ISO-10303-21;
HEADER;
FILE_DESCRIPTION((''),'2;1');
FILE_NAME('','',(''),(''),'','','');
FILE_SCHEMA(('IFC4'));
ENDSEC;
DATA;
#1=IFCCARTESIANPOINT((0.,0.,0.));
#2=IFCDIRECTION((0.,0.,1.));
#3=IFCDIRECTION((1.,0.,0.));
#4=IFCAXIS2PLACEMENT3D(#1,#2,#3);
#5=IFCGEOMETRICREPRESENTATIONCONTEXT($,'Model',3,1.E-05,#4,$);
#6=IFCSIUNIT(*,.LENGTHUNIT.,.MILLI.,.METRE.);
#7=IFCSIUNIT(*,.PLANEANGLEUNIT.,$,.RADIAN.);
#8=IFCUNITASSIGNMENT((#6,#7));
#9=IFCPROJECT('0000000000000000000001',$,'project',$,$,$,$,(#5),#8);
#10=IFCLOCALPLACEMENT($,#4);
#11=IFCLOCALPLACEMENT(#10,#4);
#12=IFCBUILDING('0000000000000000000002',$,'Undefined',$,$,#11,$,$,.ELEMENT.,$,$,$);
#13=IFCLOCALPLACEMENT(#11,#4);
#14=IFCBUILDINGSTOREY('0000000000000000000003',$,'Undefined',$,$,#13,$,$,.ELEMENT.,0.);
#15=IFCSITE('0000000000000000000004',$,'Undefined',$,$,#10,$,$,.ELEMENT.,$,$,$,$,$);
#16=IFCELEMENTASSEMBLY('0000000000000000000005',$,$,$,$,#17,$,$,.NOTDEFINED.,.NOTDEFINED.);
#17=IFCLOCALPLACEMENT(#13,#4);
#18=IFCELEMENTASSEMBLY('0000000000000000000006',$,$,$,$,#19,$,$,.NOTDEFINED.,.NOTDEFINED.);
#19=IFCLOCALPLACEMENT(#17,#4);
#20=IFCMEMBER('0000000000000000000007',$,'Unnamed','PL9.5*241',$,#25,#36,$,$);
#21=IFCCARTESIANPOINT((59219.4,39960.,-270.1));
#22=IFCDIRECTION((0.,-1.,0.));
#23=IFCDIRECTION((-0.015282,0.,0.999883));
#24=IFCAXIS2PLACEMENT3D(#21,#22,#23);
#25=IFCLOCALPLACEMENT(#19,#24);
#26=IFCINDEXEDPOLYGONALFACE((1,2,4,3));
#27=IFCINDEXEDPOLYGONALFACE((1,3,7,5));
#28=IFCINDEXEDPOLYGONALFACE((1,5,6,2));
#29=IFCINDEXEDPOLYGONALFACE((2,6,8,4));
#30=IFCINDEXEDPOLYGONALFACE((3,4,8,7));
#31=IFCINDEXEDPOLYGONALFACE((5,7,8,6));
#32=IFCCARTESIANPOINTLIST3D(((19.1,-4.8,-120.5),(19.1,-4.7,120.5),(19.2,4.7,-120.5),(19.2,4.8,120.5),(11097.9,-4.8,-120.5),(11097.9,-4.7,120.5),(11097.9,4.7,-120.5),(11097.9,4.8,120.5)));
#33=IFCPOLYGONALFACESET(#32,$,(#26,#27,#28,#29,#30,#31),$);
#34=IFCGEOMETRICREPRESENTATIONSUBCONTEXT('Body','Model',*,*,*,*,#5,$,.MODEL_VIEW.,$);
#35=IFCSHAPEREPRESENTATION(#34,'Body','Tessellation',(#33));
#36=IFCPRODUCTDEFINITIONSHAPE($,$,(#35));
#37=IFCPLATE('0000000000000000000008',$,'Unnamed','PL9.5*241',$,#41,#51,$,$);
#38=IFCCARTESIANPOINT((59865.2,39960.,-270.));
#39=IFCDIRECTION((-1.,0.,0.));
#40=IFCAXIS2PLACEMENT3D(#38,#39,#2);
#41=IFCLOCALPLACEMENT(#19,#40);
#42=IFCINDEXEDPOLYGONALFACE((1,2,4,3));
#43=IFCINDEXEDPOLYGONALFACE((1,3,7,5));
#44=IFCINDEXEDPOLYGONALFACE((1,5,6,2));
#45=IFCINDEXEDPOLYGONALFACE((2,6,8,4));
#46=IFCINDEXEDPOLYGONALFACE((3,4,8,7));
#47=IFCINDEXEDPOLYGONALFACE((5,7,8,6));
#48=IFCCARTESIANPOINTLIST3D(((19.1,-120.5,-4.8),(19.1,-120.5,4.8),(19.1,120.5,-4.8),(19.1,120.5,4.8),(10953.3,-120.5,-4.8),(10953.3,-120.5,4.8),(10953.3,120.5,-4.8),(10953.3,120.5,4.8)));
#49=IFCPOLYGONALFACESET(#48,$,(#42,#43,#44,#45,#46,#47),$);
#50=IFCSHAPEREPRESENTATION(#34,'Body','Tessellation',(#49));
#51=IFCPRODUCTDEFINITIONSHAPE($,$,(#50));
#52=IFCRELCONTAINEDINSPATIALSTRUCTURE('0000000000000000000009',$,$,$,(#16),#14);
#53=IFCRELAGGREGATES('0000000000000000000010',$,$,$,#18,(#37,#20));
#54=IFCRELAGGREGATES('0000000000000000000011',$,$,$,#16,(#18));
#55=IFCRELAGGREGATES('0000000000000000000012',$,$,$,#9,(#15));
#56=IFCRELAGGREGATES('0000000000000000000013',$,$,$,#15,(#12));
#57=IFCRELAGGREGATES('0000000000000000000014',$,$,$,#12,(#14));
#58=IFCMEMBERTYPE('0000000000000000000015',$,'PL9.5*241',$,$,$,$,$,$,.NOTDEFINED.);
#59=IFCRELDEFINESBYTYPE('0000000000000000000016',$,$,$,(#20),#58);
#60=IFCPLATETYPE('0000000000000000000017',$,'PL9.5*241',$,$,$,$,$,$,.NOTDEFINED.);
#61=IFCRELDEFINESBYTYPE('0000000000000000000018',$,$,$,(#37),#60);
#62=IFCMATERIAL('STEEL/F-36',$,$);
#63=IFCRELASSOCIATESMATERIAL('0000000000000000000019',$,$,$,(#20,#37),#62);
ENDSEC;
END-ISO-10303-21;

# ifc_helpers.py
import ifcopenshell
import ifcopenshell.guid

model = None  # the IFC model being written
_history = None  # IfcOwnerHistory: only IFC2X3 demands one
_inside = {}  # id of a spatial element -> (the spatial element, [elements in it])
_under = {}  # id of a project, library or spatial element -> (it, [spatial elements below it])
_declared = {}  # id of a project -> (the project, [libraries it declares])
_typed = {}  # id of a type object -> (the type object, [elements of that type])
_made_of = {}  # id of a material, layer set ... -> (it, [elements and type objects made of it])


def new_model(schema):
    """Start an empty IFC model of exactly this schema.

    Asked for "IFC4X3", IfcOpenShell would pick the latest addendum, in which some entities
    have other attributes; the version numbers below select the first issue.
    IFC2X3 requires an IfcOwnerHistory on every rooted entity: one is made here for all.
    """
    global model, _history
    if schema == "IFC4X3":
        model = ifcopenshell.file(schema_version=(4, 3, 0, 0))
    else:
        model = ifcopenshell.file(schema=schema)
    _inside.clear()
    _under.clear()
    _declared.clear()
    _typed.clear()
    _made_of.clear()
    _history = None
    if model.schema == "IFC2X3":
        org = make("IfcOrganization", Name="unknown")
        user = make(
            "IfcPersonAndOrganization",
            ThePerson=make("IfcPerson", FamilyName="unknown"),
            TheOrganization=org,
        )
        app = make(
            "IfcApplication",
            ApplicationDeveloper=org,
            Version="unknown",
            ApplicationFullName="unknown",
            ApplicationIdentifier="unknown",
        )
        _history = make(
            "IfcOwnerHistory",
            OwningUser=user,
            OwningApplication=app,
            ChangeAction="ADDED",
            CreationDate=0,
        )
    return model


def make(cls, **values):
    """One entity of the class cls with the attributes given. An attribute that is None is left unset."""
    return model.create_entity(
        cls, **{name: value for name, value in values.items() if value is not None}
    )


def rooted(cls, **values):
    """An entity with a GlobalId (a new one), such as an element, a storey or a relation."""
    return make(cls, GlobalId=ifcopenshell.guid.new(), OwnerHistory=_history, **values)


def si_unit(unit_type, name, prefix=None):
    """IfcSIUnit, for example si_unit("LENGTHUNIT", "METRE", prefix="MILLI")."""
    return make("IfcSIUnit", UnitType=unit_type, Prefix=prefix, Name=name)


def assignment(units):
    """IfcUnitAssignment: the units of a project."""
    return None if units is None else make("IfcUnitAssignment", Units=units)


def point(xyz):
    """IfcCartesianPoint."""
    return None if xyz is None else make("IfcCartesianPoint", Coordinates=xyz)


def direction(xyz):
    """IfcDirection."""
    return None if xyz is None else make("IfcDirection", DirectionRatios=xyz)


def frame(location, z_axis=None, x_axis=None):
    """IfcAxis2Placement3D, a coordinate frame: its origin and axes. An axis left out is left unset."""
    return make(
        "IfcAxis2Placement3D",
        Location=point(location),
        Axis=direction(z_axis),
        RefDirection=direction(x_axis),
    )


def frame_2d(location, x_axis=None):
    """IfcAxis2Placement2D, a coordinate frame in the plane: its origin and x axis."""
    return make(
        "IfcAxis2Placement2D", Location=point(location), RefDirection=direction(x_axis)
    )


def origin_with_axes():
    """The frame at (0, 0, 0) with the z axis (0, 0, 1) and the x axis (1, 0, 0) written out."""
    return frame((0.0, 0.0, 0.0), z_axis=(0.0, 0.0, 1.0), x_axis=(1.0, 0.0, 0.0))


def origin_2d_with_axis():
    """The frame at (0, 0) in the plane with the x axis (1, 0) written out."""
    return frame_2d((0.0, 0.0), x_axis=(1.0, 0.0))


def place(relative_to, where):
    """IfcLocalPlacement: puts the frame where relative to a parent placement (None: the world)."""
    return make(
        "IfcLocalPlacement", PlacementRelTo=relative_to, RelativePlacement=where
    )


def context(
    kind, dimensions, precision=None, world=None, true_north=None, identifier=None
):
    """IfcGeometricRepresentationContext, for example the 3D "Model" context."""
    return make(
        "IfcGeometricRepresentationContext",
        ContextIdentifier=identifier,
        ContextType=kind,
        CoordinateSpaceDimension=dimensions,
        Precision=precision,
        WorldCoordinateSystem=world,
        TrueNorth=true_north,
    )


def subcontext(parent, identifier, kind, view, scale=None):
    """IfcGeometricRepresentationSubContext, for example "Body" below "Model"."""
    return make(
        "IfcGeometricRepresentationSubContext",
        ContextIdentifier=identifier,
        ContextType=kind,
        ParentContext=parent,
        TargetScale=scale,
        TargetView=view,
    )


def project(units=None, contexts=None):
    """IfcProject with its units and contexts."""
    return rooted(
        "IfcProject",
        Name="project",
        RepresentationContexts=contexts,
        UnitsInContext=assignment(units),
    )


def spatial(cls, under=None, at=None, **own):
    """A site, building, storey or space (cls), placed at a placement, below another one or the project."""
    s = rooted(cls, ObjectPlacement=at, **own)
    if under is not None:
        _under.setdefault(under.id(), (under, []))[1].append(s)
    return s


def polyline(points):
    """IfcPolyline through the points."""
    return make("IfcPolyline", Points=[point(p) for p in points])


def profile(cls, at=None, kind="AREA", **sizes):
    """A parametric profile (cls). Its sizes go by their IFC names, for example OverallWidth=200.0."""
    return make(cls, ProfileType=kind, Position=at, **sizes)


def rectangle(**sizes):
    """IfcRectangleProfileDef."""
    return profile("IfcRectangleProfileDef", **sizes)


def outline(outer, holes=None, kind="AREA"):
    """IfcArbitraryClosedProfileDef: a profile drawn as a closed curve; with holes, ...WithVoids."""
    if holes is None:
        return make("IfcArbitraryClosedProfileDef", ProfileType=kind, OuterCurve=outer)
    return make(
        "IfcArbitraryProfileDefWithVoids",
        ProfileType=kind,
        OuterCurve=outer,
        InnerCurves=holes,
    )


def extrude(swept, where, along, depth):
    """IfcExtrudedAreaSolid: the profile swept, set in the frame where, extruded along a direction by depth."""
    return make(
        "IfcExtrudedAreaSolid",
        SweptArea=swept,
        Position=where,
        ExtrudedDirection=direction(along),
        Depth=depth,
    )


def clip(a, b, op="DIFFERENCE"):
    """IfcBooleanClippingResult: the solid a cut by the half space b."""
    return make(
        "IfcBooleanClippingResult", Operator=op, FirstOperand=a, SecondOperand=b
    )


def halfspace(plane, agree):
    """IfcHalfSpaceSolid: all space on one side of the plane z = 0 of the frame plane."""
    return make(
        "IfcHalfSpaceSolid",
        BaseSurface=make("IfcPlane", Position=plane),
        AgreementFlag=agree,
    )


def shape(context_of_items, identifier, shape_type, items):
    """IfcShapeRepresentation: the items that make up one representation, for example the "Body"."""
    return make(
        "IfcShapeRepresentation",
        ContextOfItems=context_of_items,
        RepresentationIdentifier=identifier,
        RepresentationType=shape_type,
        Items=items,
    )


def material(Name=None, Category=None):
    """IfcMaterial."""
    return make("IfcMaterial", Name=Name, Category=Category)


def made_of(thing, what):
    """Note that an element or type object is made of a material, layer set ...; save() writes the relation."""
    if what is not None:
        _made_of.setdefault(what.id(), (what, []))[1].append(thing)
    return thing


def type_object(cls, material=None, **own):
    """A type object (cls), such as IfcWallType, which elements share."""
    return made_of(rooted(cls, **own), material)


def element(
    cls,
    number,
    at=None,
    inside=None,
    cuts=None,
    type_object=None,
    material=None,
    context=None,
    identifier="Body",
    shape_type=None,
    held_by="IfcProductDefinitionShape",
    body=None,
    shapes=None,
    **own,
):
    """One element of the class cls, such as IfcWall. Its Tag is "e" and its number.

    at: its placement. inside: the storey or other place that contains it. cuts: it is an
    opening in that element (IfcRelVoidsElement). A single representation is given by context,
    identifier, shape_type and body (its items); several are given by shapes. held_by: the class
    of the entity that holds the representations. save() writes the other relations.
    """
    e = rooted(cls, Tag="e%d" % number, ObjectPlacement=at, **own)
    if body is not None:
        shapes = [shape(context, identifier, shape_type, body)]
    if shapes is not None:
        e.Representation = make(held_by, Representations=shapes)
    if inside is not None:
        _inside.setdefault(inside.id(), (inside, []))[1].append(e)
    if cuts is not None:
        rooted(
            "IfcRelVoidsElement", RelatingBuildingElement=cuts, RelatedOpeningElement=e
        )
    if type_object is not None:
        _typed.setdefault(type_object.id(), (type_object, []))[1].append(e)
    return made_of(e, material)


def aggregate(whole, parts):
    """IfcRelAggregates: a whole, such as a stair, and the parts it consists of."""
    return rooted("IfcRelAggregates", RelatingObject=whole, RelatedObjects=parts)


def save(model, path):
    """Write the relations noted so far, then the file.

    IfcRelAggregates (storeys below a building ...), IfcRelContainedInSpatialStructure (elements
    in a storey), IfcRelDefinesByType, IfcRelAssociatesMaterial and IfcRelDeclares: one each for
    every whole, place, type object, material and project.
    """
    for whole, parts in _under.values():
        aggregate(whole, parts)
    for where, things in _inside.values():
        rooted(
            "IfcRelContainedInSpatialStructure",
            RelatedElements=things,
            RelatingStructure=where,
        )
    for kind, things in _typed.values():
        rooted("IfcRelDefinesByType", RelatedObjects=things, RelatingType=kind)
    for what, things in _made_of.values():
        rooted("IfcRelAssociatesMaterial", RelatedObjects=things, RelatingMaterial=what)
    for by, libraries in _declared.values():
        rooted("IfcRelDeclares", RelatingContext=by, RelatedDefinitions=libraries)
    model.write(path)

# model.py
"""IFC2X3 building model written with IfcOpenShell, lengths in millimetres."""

from ifc_helpers import new_model, si_unit, frame, origin_with_axes, origin_2d_with_axis, place, context, subcontext, project, spatial, polyline, rectangle, outline, extrude, clip, halfspace, material, type_object, element, aggregate, save


model = new_model("IFC2X3")

# Units and contexts
model_context = context("Model", 3, precision=1e-05, world=origin_with_axes())
body_context = subcontext(model_context, "Body", "Model", "MODEL_VIEW")
ifc_project = project(units=[si_unit("LENGTHUNIT", "METRE", prefix="MILLI"), si_unit("PLANEANGLEUNIT", "RADIAN")], contexts=[model_context])

# Site, building, storey
site_placement = place(None, origin_with_axes())
site = spatial("IfcSite", under=ifc_project, at=site_placement, Name="Undefined", CompositionType="ELEMENT")
building_placement = place(site_placement, origin_with_axes())
building = spatial("IfcBuilding", under=site, at=building_placement, Name="Undefined", CompositionType="ELEMENT")
storey_placement = place(building_placement, origin_with_axes())
storey = spatial("IfcBuildingStorey", under=building, at=storey_placement, Name="Undefined", CompositionType="ELEMENT", Elevation=0.0)

# Element assemblies, member
assembly_1_placement = place(storey_placement, origin_with_axes())
assembly_1 = element("IfcElementAssembly", 1, at=assembly_1_placement, inside=storey, AssemblyPlace="NOTDEFINED", PredefinedType="NOTDEFINED")
assembly_2_placement = place(assembly_1_placement, origin_with_axes())
assembly_2 = element("IfcElementAssembly", 2, at=assembly_2_placement, AssemblyPlace="NOTDEFINED", PredefinedType="NOTDEFINED")
ifc_material_1 = material(Name="STEEL/F-36")
member_type = type_object("IfcMemberType", Name="PL9.5*241", PredefinedType="NOTDEFINED")
member_placement = place(assembly_2_placement, frame((59219.4, 39960.0, -270.1), z_axis=(0.0, -1.0, 0.0), x_axis=(-0.015282, 0.0, 0.999883)))
member = element("IfcMember", 3, at=member_placement, type_object=member_type, material=ifc_material_1, Name="Unnamed", Description="PL9.5*241", context=body_context, shape_type="Clipping", body=[
    clip(extrude(rectangle(XDim=9.5, YDim=241.0, at=origin_2d_with_axis()), frame((11097.9, 0.0, 0.0), z_axis=(-1.0, 0.0, 0.0), x_axis=(0.0, -1.0, 0.0)), (0.0, 0.0, 1.0), 11097.9), halfspace(frame((19.1, 0.0, 0.0), z_axis=(0.999883, -0.015282, 0.0), x_axis=(0.0, 0.0, 1.0)), True)),
])

# Plate
plate_type_1 = type_object("IfcPlateType", Name="PL9.5*241", PredefinedType="NOTDEFINED")
plate_1_placement = place(assembly_2_placement, frame((59865.2, 39960.0, -270.0), z_axis=(-1.0, 0.0, 0.0), x_axis=(0.0, 0.0, 1.0)))
plate_1 = element("IfcPlate", 4, at=plate_1_placement, type_object=plate_type_1, material=ifc_material_1, Name="Unnamed", Description="PL9.5*241", context=body_context, shape_type="Clipping", body=[
    clip(extrude(outline(polyline([(19.1, -120.5), (19.1, 120.5), (10953.3, 120.5), (10953.3, -120.5), (19.1, -120.5)])), frame((0.0, 0.0, -4.8), z_axis=(0.0, 0.0, 1.0), x_axis=(1.0, 0.0, 0.0)), (0.0, 0.0, 1.0), 9.5), halfspace(frame((19.1, 0.0, 0.0), z_axis=(-1.0, 0.0, 0.0), x_axis=(0.0, 0.0, 1.0)), False)),
])
aggregate(assembly_2, [plate_1, member])

aggregate(assembly_1, [assembly_2])

save(model, "model.ifc")
